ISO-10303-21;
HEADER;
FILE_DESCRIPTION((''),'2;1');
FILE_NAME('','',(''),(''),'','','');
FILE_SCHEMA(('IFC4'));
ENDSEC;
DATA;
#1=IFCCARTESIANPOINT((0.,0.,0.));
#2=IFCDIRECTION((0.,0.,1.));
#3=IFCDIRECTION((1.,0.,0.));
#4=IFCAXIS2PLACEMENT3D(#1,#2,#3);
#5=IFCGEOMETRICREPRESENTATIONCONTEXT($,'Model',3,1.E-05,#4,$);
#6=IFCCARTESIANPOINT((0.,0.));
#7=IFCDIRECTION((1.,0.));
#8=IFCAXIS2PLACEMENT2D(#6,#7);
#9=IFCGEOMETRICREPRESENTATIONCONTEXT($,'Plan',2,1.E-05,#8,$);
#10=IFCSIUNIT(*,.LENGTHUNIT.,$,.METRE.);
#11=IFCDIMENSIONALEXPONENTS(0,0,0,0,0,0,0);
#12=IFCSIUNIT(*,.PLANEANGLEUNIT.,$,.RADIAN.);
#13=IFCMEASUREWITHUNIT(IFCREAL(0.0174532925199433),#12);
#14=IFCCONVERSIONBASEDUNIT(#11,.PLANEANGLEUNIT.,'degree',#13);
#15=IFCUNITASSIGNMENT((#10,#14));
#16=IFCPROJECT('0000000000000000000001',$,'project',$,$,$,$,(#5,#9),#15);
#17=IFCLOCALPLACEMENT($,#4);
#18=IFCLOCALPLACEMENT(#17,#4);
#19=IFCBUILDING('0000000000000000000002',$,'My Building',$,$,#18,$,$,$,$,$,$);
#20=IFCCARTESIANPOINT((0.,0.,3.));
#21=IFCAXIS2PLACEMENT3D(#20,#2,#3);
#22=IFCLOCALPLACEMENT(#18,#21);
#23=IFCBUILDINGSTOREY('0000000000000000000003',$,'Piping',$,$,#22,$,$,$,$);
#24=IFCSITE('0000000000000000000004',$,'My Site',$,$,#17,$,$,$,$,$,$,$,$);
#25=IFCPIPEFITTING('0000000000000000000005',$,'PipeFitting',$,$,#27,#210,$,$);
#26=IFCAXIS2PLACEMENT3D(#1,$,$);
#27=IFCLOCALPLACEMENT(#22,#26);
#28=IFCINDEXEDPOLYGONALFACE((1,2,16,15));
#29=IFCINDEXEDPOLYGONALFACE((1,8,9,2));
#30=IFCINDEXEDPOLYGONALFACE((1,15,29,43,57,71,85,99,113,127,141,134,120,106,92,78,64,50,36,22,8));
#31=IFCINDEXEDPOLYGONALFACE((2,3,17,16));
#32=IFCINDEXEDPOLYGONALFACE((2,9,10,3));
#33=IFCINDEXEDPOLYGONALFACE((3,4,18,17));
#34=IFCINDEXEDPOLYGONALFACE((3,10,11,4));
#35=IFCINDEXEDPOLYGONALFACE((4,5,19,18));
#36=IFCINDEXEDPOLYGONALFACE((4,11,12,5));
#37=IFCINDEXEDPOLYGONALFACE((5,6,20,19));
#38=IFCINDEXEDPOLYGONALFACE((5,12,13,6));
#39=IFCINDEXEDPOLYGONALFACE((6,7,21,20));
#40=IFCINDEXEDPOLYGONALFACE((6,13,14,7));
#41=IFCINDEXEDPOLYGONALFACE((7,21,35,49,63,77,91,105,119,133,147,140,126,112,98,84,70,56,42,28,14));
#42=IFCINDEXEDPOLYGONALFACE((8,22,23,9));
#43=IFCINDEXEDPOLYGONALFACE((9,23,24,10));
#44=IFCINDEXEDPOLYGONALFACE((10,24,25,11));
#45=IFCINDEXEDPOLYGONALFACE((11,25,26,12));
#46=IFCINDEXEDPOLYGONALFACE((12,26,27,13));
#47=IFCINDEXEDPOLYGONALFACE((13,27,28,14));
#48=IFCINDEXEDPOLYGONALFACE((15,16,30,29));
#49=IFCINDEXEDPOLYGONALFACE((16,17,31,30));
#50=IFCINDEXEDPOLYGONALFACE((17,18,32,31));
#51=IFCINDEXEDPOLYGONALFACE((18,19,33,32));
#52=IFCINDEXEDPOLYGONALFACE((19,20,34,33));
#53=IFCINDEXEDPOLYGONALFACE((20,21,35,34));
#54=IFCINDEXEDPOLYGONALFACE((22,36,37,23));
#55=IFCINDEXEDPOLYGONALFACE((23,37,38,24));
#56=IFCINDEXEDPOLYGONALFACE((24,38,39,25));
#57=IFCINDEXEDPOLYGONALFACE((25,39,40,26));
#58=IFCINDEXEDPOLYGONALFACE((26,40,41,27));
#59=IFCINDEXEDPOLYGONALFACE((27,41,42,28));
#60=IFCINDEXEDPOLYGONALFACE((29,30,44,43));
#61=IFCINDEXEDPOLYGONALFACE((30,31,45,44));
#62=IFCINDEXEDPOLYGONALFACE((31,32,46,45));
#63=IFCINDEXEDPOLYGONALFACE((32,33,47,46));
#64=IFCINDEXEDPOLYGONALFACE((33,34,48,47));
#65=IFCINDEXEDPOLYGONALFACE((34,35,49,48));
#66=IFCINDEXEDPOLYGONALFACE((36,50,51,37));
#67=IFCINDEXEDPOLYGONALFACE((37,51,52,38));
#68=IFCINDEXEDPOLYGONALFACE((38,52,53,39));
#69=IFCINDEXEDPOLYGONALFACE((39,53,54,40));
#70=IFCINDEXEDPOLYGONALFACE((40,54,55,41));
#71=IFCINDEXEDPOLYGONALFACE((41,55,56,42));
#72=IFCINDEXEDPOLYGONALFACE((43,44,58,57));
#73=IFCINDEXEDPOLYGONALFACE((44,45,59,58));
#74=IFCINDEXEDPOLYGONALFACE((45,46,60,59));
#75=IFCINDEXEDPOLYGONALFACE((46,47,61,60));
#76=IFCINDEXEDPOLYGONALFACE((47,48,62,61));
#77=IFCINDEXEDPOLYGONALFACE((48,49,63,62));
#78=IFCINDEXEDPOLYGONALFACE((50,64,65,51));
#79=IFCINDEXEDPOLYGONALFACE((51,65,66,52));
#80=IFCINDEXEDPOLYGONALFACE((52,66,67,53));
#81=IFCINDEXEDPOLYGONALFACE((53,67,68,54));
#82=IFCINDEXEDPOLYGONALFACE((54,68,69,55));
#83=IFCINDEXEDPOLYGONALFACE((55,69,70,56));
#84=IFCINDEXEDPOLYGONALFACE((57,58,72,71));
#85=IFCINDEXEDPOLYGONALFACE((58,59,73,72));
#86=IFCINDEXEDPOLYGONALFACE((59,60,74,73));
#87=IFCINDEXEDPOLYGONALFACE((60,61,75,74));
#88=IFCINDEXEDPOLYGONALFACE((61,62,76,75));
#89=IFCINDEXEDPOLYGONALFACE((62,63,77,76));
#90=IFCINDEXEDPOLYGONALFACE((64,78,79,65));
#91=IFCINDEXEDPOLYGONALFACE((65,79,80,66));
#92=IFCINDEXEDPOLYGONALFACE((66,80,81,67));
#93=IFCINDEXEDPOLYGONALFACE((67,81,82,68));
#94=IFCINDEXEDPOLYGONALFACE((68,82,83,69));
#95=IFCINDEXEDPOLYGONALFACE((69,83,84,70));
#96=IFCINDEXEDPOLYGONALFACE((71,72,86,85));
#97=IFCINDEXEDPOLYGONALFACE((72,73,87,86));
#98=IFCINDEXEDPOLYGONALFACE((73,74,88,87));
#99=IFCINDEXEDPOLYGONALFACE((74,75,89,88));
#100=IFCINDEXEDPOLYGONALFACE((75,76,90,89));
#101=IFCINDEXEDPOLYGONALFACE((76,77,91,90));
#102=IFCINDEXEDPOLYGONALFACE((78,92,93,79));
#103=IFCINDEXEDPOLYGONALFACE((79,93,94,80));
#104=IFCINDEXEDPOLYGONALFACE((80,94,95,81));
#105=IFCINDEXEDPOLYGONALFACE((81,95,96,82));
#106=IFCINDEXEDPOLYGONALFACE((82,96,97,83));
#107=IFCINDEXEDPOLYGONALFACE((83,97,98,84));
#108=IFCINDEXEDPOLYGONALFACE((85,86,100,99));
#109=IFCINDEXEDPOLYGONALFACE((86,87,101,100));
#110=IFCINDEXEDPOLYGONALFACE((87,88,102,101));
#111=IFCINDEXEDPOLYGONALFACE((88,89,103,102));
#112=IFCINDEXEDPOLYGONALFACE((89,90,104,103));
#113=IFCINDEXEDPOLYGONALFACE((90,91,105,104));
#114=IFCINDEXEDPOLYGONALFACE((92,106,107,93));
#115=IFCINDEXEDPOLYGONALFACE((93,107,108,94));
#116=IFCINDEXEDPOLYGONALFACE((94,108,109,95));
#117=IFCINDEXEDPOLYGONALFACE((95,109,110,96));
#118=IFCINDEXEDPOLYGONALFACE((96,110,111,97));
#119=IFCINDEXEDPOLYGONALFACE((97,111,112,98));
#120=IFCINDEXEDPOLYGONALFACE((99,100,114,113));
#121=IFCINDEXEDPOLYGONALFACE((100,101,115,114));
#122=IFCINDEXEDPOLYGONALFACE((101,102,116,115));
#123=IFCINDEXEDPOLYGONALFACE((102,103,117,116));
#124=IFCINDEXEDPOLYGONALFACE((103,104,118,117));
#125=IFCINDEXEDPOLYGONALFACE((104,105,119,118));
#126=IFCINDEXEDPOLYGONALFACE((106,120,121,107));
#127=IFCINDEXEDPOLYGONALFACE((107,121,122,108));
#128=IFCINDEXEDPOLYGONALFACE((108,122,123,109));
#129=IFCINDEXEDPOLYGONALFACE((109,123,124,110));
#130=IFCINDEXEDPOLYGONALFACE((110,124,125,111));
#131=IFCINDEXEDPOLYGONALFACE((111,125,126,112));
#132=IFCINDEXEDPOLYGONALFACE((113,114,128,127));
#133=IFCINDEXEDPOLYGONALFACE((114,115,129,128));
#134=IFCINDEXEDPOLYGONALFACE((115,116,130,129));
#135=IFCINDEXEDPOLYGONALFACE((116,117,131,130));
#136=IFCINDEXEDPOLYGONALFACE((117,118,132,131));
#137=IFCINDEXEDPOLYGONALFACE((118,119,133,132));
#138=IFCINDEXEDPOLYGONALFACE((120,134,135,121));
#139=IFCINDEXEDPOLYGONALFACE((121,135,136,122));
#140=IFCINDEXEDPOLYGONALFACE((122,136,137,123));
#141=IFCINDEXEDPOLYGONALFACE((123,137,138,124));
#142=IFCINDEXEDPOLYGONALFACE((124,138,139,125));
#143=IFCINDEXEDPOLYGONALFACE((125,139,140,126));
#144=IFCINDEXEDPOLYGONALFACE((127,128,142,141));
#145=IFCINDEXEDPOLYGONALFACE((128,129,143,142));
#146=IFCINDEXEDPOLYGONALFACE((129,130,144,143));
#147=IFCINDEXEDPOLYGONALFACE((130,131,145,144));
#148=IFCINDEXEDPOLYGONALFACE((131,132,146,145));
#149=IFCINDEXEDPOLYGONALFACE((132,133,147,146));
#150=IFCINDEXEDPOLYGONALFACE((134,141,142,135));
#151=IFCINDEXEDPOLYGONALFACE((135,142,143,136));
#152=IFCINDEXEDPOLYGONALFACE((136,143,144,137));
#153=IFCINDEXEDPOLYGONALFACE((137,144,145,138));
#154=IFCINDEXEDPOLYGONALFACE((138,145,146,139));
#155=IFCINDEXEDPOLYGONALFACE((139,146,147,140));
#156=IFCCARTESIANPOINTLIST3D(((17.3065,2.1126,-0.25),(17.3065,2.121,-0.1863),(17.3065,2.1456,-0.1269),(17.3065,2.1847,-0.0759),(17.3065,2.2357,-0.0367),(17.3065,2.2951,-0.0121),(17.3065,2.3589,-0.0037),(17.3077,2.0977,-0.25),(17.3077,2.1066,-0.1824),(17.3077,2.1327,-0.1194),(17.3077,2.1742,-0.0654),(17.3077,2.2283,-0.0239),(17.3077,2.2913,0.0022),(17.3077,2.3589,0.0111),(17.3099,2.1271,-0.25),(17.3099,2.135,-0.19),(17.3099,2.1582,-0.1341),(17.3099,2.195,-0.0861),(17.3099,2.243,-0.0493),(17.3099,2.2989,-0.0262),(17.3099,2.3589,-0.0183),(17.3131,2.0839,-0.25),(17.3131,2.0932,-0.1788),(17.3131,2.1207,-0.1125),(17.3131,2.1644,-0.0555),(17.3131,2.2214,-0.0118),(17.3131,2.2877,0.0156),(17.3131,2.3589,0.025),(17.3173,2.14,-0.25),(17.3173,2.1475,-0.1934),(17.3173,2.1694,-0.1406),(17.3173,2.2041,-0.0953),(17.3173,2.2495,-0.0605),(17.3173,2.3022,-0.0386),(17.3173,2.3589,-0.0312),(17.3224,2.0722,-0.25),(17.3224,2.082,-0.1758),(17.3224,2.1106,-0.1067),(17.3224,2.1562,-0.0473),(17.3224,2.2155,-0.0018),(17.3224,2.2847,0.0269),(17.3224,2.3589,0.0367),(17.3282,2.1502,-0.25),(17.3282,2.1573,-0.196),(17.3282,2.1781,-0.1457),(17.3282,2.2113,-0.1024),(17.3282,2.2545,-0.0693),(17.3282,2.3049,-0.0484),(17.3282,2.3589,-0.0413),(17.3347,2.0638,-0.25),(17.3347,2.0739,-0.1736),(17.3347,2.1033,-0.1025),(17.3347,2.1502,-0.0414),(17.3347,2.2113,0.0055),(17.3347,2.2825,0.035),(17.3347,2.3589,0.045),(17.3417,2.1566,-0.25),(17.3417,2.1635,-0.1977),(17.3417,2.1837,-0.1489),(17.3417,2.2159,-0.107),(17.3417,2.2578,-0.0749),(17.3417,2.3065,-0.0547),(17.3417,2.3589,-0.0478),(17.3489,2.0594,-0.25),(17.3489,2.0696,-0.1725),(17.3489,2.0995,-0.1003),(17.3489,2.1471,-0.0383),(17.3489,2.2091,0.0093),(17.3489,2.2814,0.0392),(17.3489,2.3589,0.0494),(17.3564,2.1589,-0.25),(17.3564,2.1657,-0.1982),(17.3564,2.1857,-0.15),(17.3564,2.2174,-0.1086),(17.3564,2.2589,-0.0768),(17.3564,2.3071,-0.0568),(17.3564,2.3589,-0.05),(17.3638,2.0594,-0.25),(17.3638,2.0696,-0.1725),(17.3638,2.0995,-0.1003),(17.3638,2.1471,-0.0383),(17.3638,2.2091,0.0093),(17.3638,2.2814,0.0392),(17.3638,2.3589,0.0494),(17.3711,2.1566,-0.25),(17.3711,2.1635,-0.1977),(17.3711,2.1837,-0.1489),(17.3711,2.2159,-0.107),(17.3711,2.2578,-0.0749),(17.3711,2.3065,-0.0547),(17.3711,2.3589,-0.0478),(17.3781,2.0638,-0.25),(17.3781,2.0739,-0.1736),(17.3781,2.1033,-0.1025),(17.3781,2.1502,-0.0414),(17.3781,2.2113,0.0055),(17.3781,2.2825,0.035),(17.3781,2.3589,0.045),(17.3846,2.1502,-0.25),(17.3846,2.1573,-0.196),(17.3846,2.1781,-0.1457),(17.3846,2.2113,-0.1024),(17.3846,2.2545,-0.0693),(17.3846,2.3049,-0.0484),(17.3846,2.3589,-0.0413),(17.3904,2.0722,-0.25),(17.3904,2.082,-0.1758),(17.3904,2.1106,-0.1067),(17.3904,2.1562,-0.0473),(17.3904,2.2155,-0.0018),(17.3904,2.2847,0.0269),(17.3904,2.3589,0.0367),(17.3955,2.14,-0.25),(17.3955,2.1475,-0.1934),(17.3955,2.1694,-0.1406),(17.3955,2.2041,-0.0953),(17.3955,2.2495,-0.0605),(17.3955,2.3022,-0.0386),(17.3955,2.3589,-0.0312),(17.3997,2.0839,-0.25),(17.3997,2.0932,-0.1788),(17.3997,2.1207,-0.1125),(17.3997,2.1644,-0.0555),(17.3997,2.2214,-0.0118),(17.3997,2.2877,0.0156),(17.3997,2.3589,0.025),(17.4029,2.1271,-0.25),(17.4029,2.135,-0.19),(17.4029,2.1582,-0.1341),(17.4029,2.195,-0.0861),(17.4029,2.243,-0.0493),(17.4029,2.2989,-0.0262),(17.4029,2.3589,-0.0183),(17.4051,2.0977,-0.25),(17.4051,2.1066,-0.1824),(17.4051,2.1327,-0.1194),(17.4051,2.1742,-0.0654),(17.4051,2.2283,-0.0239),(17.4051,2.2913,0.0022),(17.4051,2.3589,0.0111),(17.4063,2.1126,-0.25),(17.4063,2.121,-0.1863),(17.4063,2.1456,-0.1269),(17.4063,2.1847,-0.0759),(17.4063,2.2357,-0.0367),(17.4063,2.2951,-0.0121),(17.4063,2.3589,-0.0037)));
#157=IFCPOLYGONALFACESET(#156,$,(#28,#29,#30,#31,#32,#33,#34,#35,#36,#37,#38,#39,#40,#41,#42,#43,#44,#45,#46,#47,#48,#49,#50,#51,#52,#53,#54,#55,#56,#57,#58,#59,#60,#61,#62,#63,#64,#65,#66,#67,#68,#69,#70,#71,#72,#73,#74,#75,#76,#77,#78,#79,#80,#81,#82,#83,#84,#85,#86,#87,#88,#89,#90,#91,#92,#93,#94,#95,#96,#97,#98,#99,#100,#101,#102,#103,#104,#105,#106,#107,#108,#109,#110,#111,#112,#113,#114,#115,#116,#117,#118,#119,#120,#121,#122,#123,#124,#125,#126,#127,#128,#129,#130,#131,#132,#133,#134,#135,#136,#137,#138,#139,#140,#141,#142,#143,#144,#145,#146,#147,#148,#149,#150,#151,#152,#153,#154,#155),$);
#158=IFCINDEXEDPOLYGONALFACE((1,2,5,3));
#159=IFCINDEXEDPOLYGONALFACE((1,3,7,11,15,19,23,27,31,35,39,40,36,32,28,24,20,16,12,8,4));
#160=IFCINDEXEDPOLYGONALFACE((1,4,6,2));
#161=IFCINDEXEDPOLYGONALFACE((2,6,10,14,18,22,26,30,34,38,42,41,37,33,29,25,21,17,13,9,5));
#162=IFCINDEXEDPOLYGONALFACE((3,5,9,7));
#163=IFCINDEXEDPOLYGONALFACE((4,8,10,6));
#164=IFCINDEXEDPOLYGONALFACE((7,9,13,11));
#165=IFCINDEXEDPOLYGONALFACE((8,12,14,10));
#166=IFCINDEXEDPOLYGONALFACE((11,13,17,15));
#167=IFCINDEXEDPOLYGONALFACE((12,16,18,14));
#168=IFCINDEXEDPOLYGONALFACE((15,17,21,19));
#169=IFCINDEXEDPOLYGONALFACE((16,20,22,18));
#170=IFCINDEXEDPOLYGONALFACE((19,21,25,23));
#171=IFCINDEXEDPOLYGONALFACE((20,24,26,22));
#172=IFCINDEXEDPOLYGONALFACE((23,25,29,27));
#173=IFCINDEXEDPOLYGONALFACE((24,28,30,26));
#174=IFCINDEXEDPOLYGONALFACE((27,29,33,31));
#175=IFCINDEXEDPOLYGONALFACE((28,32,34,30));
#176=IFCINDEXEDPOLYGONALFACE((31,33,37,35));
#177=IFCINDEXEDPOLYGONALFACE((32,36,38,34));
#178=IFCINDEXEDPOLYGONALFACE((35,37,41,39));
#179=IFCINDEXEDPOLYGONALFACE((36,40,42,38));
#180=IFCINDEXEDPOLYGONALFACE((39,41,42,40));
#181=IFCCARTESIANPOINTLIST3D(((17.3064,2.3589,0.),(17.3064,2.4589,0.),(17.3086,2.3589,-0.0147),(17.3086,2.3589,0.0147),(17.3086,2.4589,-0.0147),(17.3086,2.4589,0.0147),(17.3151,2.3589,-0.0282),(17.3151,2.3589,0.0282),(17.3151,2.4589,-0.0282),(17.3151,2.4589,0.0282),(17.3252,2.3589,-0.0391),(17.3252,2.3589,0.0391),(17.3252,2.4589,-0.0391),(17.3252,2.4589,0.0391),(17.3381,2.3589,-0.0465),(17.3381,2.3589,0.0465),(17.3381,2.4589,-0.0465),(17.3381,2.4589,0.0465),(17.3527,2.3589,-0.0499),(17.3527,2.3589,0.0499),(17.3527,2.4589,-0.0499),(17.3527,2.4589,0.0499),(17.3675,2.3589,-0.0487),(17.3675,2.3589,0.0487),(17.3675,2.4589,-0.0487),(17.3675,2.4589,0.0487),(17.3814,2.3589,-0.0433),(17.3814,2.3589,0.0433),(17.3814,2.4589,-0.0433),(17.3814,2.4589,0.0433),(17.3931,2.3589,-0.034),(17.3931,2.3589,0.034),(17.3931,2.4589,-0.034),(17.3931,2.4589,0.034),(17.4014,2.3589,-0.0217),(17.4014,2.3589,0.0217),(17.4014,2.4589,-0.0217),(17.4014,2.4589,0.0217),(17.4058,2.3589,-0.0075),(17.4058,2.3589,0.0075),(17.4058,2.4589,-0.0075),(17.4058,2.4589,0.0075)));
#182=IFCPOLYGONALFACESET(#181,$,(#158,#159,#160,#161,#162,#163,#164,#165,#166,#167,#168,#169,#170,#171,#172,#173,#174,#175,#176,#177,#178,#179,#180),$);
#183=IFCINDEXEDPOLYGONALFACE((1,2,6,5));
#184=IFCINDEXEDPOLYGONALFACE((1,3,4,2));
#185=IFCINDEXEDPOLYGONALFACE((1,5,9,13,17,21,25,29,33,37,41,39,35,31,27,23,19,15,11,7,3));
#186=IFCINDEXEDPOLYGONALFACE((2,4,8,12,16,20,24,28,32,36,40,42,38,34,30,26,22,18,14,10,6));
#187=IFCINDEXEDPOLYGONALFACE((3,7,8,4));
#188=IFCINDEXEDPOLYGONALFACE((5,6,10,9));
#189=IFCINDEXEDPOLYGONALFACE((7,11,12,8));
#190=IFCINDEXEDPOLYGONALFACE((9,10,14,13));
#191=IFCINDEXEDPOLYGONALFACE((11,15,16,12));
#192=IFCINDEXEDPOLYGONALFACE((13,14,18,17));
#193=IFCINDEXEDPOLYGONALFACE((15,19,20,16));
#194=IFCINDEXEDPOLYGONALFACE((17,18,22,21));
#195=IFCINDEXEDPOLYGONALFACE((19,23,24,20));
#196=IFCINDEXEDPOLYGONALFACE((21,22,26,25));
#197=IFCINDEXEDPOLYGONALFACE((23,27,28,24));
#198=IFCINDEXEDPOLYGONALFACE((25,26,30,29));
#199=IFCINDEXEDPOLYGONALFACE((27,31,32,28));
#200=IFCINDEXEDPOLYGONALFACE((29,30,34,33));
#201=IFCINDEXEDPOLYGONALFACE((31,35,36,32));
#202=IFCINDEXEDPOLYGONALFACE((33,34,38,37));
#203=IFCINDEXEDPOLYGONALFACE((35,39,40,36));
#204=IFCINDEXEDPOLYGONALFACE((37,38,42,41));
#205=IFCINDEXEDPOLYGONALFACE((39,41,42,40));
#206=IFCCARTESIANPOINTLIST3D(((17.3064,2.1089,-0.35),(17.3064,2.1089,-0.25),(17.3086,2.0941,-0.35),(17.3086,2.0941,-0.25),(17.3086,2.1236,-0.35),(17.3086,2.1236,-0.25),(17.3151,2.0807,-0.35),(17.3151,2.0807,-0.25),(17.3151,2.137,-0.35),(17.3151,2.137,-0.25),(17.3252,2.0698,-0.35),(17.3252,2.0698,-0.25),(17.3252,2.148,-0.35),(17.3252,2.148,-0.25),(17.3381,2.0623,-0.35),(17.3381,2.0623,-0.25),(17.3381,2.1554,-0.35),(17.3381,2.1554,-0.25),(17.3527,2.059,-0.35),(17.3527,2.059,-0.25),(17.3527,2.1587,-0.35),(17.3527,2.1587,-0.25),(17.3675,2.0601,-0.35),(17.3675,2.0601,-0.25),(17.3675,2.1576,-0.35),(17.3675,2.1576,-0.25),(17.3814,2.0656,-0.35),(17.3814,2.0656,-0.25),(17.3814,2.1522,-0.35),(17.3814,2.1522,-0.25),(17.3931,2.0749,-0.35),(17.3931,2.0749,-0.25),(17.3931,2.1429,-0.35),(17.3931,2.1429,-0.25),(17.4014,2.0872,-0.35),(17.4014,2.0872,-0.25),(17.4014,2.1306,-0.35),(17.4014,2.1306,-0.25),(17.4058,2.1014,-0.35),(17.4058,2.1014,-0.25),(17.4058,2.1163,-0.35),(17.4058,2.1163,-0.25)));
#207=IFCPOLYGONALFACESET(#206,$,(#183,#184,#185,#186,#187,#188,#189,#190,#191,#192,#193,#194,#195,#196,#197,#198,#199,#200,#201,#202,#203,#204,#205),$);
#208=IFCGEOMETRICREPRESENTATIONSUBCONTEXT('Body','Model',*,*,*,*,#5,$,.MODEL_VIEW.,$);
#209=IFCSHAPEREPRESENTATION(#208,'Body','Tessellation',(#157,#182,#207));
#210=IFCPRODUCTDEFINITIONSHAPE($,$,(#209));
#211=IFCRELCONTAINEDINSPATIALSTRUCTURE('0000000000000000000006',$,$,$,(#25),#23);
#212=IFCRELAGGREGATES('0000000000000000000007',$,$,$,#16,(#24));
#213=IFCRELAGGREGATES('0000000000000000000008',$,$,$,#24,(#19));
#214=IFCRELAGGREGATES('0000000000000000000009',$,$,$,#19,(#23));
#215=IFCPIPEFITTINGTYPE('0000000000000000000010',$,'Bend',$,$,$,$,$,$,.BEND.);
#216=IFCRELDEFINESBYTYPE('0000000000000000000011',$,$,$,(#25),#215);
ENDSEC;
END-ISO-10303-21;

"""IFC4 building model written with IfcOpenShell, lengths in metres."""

from ifc_helpers import new_model, entity, si_unit, converted_unit, frame, origin_with_axes, origin_2d_with_axis, place, context, subcontext, project, spatial, circle, extrude, source, transform, mapped, type_object, type_shapes, element, save


model = new_model("IFC4")

# Units and contexts
model_context = context("Model", 3, precision=1e-05, world=origin_with_axes())
plan_context = context("Plan", 2, precision=1e-05, world=origin_2d_with_axis())
body_context = subcontext(model_context, "Body", "Model", "MODEL_VIEW")
ifc_project = project(units=[si_unit("LENGTHUNIT", "METRE"), converted_unit("PLANEANGLEUNIT", "degree", entity("IfcReal", 0.0174532925199433), si_unit("PLANEANGLEUNIT", "RADIAN"), dimensions=[0, 0, 0, 0, 0, 0, 0])], contexts=[model_context, plan_context])

# Site, building, storey
site_placement = place(None, origin_with_axes())
site = spatial("IfcSite", under=ifc_project, at=site_placement, Name="My Site")
building_placement = place(site_placement, origin_with_axes())
building = spatial("IfcBuilding", under=site, at=building_placement, Name="My Building")
storey_placement = place(building_placement, frame((0.0, 0.0, 3.0), z_axis=(0.0, 0.0, 1.0), x_axis=(1.0, 0.0, 0.0)))
storey = spatial("IfcBuildingStorey", under=building, at=storey_placement, Name="Piping")

# Shared definitions
pipe_fitting_type = type_object("IfcPipeFittingType", Name="Bend", PredefinedType="BEND")
shared_shape = source(origin_with_axes(), body_context, "Body", "SolidModel", [
    entity("IfcSweptDiskSolid", entity("IfcIndexedPolyCurve", entity("IfcCartesianPointList3D", [[0.0, 0.0, -0.1], [0.0, -0.0732, -0.2768], [0.0, -0.25, -0.35]]), [entity("IfcArcIndex", [1, 2, 3])]), 0.05),
    extrude(circle(Radius=0.05), origin_with_axes(), (0.0, 0.0, -1.0), 0.1),
    extrude(circle(Radius=0.05), frame((0.0, -0.25, -0.35), z_axis=(0.0, -1.0, 0.0), x_axis=(1.0, 0.0, 0.0)), (0.0, 0.0, 1.0), 0.1),
])
type_shapes(pipe_fitting_type, [shared_shape])

# Pipe fitting
for number, where, z_axis, x_axis, name in (
    (1, (17.3564, 2.4589, 0.0), (0.0, 1.0, 0.0), (-1.0, 0.0, 0.0), "PipeFitting"),
):
    element("IfcPipeFitting", number, at=place(storey_placement, frame(where, z_axis=z_axis, x_axis=x_axis)), inside=storey, type_object=pipe_fitting_type, Name=name, context=body_context, shape_type="MappedRepresentation", body=[
        mapped(shared_shape, transform((0.0, 0.0, 0.0), x_axis=(1.0, 0.0, 0.0), y_axis=(0.0, 1.0, 0.0), z_axis=(0.0, 0.0, 1.0), scale=1.0)),
    ])

save(model, "model.ifc")
